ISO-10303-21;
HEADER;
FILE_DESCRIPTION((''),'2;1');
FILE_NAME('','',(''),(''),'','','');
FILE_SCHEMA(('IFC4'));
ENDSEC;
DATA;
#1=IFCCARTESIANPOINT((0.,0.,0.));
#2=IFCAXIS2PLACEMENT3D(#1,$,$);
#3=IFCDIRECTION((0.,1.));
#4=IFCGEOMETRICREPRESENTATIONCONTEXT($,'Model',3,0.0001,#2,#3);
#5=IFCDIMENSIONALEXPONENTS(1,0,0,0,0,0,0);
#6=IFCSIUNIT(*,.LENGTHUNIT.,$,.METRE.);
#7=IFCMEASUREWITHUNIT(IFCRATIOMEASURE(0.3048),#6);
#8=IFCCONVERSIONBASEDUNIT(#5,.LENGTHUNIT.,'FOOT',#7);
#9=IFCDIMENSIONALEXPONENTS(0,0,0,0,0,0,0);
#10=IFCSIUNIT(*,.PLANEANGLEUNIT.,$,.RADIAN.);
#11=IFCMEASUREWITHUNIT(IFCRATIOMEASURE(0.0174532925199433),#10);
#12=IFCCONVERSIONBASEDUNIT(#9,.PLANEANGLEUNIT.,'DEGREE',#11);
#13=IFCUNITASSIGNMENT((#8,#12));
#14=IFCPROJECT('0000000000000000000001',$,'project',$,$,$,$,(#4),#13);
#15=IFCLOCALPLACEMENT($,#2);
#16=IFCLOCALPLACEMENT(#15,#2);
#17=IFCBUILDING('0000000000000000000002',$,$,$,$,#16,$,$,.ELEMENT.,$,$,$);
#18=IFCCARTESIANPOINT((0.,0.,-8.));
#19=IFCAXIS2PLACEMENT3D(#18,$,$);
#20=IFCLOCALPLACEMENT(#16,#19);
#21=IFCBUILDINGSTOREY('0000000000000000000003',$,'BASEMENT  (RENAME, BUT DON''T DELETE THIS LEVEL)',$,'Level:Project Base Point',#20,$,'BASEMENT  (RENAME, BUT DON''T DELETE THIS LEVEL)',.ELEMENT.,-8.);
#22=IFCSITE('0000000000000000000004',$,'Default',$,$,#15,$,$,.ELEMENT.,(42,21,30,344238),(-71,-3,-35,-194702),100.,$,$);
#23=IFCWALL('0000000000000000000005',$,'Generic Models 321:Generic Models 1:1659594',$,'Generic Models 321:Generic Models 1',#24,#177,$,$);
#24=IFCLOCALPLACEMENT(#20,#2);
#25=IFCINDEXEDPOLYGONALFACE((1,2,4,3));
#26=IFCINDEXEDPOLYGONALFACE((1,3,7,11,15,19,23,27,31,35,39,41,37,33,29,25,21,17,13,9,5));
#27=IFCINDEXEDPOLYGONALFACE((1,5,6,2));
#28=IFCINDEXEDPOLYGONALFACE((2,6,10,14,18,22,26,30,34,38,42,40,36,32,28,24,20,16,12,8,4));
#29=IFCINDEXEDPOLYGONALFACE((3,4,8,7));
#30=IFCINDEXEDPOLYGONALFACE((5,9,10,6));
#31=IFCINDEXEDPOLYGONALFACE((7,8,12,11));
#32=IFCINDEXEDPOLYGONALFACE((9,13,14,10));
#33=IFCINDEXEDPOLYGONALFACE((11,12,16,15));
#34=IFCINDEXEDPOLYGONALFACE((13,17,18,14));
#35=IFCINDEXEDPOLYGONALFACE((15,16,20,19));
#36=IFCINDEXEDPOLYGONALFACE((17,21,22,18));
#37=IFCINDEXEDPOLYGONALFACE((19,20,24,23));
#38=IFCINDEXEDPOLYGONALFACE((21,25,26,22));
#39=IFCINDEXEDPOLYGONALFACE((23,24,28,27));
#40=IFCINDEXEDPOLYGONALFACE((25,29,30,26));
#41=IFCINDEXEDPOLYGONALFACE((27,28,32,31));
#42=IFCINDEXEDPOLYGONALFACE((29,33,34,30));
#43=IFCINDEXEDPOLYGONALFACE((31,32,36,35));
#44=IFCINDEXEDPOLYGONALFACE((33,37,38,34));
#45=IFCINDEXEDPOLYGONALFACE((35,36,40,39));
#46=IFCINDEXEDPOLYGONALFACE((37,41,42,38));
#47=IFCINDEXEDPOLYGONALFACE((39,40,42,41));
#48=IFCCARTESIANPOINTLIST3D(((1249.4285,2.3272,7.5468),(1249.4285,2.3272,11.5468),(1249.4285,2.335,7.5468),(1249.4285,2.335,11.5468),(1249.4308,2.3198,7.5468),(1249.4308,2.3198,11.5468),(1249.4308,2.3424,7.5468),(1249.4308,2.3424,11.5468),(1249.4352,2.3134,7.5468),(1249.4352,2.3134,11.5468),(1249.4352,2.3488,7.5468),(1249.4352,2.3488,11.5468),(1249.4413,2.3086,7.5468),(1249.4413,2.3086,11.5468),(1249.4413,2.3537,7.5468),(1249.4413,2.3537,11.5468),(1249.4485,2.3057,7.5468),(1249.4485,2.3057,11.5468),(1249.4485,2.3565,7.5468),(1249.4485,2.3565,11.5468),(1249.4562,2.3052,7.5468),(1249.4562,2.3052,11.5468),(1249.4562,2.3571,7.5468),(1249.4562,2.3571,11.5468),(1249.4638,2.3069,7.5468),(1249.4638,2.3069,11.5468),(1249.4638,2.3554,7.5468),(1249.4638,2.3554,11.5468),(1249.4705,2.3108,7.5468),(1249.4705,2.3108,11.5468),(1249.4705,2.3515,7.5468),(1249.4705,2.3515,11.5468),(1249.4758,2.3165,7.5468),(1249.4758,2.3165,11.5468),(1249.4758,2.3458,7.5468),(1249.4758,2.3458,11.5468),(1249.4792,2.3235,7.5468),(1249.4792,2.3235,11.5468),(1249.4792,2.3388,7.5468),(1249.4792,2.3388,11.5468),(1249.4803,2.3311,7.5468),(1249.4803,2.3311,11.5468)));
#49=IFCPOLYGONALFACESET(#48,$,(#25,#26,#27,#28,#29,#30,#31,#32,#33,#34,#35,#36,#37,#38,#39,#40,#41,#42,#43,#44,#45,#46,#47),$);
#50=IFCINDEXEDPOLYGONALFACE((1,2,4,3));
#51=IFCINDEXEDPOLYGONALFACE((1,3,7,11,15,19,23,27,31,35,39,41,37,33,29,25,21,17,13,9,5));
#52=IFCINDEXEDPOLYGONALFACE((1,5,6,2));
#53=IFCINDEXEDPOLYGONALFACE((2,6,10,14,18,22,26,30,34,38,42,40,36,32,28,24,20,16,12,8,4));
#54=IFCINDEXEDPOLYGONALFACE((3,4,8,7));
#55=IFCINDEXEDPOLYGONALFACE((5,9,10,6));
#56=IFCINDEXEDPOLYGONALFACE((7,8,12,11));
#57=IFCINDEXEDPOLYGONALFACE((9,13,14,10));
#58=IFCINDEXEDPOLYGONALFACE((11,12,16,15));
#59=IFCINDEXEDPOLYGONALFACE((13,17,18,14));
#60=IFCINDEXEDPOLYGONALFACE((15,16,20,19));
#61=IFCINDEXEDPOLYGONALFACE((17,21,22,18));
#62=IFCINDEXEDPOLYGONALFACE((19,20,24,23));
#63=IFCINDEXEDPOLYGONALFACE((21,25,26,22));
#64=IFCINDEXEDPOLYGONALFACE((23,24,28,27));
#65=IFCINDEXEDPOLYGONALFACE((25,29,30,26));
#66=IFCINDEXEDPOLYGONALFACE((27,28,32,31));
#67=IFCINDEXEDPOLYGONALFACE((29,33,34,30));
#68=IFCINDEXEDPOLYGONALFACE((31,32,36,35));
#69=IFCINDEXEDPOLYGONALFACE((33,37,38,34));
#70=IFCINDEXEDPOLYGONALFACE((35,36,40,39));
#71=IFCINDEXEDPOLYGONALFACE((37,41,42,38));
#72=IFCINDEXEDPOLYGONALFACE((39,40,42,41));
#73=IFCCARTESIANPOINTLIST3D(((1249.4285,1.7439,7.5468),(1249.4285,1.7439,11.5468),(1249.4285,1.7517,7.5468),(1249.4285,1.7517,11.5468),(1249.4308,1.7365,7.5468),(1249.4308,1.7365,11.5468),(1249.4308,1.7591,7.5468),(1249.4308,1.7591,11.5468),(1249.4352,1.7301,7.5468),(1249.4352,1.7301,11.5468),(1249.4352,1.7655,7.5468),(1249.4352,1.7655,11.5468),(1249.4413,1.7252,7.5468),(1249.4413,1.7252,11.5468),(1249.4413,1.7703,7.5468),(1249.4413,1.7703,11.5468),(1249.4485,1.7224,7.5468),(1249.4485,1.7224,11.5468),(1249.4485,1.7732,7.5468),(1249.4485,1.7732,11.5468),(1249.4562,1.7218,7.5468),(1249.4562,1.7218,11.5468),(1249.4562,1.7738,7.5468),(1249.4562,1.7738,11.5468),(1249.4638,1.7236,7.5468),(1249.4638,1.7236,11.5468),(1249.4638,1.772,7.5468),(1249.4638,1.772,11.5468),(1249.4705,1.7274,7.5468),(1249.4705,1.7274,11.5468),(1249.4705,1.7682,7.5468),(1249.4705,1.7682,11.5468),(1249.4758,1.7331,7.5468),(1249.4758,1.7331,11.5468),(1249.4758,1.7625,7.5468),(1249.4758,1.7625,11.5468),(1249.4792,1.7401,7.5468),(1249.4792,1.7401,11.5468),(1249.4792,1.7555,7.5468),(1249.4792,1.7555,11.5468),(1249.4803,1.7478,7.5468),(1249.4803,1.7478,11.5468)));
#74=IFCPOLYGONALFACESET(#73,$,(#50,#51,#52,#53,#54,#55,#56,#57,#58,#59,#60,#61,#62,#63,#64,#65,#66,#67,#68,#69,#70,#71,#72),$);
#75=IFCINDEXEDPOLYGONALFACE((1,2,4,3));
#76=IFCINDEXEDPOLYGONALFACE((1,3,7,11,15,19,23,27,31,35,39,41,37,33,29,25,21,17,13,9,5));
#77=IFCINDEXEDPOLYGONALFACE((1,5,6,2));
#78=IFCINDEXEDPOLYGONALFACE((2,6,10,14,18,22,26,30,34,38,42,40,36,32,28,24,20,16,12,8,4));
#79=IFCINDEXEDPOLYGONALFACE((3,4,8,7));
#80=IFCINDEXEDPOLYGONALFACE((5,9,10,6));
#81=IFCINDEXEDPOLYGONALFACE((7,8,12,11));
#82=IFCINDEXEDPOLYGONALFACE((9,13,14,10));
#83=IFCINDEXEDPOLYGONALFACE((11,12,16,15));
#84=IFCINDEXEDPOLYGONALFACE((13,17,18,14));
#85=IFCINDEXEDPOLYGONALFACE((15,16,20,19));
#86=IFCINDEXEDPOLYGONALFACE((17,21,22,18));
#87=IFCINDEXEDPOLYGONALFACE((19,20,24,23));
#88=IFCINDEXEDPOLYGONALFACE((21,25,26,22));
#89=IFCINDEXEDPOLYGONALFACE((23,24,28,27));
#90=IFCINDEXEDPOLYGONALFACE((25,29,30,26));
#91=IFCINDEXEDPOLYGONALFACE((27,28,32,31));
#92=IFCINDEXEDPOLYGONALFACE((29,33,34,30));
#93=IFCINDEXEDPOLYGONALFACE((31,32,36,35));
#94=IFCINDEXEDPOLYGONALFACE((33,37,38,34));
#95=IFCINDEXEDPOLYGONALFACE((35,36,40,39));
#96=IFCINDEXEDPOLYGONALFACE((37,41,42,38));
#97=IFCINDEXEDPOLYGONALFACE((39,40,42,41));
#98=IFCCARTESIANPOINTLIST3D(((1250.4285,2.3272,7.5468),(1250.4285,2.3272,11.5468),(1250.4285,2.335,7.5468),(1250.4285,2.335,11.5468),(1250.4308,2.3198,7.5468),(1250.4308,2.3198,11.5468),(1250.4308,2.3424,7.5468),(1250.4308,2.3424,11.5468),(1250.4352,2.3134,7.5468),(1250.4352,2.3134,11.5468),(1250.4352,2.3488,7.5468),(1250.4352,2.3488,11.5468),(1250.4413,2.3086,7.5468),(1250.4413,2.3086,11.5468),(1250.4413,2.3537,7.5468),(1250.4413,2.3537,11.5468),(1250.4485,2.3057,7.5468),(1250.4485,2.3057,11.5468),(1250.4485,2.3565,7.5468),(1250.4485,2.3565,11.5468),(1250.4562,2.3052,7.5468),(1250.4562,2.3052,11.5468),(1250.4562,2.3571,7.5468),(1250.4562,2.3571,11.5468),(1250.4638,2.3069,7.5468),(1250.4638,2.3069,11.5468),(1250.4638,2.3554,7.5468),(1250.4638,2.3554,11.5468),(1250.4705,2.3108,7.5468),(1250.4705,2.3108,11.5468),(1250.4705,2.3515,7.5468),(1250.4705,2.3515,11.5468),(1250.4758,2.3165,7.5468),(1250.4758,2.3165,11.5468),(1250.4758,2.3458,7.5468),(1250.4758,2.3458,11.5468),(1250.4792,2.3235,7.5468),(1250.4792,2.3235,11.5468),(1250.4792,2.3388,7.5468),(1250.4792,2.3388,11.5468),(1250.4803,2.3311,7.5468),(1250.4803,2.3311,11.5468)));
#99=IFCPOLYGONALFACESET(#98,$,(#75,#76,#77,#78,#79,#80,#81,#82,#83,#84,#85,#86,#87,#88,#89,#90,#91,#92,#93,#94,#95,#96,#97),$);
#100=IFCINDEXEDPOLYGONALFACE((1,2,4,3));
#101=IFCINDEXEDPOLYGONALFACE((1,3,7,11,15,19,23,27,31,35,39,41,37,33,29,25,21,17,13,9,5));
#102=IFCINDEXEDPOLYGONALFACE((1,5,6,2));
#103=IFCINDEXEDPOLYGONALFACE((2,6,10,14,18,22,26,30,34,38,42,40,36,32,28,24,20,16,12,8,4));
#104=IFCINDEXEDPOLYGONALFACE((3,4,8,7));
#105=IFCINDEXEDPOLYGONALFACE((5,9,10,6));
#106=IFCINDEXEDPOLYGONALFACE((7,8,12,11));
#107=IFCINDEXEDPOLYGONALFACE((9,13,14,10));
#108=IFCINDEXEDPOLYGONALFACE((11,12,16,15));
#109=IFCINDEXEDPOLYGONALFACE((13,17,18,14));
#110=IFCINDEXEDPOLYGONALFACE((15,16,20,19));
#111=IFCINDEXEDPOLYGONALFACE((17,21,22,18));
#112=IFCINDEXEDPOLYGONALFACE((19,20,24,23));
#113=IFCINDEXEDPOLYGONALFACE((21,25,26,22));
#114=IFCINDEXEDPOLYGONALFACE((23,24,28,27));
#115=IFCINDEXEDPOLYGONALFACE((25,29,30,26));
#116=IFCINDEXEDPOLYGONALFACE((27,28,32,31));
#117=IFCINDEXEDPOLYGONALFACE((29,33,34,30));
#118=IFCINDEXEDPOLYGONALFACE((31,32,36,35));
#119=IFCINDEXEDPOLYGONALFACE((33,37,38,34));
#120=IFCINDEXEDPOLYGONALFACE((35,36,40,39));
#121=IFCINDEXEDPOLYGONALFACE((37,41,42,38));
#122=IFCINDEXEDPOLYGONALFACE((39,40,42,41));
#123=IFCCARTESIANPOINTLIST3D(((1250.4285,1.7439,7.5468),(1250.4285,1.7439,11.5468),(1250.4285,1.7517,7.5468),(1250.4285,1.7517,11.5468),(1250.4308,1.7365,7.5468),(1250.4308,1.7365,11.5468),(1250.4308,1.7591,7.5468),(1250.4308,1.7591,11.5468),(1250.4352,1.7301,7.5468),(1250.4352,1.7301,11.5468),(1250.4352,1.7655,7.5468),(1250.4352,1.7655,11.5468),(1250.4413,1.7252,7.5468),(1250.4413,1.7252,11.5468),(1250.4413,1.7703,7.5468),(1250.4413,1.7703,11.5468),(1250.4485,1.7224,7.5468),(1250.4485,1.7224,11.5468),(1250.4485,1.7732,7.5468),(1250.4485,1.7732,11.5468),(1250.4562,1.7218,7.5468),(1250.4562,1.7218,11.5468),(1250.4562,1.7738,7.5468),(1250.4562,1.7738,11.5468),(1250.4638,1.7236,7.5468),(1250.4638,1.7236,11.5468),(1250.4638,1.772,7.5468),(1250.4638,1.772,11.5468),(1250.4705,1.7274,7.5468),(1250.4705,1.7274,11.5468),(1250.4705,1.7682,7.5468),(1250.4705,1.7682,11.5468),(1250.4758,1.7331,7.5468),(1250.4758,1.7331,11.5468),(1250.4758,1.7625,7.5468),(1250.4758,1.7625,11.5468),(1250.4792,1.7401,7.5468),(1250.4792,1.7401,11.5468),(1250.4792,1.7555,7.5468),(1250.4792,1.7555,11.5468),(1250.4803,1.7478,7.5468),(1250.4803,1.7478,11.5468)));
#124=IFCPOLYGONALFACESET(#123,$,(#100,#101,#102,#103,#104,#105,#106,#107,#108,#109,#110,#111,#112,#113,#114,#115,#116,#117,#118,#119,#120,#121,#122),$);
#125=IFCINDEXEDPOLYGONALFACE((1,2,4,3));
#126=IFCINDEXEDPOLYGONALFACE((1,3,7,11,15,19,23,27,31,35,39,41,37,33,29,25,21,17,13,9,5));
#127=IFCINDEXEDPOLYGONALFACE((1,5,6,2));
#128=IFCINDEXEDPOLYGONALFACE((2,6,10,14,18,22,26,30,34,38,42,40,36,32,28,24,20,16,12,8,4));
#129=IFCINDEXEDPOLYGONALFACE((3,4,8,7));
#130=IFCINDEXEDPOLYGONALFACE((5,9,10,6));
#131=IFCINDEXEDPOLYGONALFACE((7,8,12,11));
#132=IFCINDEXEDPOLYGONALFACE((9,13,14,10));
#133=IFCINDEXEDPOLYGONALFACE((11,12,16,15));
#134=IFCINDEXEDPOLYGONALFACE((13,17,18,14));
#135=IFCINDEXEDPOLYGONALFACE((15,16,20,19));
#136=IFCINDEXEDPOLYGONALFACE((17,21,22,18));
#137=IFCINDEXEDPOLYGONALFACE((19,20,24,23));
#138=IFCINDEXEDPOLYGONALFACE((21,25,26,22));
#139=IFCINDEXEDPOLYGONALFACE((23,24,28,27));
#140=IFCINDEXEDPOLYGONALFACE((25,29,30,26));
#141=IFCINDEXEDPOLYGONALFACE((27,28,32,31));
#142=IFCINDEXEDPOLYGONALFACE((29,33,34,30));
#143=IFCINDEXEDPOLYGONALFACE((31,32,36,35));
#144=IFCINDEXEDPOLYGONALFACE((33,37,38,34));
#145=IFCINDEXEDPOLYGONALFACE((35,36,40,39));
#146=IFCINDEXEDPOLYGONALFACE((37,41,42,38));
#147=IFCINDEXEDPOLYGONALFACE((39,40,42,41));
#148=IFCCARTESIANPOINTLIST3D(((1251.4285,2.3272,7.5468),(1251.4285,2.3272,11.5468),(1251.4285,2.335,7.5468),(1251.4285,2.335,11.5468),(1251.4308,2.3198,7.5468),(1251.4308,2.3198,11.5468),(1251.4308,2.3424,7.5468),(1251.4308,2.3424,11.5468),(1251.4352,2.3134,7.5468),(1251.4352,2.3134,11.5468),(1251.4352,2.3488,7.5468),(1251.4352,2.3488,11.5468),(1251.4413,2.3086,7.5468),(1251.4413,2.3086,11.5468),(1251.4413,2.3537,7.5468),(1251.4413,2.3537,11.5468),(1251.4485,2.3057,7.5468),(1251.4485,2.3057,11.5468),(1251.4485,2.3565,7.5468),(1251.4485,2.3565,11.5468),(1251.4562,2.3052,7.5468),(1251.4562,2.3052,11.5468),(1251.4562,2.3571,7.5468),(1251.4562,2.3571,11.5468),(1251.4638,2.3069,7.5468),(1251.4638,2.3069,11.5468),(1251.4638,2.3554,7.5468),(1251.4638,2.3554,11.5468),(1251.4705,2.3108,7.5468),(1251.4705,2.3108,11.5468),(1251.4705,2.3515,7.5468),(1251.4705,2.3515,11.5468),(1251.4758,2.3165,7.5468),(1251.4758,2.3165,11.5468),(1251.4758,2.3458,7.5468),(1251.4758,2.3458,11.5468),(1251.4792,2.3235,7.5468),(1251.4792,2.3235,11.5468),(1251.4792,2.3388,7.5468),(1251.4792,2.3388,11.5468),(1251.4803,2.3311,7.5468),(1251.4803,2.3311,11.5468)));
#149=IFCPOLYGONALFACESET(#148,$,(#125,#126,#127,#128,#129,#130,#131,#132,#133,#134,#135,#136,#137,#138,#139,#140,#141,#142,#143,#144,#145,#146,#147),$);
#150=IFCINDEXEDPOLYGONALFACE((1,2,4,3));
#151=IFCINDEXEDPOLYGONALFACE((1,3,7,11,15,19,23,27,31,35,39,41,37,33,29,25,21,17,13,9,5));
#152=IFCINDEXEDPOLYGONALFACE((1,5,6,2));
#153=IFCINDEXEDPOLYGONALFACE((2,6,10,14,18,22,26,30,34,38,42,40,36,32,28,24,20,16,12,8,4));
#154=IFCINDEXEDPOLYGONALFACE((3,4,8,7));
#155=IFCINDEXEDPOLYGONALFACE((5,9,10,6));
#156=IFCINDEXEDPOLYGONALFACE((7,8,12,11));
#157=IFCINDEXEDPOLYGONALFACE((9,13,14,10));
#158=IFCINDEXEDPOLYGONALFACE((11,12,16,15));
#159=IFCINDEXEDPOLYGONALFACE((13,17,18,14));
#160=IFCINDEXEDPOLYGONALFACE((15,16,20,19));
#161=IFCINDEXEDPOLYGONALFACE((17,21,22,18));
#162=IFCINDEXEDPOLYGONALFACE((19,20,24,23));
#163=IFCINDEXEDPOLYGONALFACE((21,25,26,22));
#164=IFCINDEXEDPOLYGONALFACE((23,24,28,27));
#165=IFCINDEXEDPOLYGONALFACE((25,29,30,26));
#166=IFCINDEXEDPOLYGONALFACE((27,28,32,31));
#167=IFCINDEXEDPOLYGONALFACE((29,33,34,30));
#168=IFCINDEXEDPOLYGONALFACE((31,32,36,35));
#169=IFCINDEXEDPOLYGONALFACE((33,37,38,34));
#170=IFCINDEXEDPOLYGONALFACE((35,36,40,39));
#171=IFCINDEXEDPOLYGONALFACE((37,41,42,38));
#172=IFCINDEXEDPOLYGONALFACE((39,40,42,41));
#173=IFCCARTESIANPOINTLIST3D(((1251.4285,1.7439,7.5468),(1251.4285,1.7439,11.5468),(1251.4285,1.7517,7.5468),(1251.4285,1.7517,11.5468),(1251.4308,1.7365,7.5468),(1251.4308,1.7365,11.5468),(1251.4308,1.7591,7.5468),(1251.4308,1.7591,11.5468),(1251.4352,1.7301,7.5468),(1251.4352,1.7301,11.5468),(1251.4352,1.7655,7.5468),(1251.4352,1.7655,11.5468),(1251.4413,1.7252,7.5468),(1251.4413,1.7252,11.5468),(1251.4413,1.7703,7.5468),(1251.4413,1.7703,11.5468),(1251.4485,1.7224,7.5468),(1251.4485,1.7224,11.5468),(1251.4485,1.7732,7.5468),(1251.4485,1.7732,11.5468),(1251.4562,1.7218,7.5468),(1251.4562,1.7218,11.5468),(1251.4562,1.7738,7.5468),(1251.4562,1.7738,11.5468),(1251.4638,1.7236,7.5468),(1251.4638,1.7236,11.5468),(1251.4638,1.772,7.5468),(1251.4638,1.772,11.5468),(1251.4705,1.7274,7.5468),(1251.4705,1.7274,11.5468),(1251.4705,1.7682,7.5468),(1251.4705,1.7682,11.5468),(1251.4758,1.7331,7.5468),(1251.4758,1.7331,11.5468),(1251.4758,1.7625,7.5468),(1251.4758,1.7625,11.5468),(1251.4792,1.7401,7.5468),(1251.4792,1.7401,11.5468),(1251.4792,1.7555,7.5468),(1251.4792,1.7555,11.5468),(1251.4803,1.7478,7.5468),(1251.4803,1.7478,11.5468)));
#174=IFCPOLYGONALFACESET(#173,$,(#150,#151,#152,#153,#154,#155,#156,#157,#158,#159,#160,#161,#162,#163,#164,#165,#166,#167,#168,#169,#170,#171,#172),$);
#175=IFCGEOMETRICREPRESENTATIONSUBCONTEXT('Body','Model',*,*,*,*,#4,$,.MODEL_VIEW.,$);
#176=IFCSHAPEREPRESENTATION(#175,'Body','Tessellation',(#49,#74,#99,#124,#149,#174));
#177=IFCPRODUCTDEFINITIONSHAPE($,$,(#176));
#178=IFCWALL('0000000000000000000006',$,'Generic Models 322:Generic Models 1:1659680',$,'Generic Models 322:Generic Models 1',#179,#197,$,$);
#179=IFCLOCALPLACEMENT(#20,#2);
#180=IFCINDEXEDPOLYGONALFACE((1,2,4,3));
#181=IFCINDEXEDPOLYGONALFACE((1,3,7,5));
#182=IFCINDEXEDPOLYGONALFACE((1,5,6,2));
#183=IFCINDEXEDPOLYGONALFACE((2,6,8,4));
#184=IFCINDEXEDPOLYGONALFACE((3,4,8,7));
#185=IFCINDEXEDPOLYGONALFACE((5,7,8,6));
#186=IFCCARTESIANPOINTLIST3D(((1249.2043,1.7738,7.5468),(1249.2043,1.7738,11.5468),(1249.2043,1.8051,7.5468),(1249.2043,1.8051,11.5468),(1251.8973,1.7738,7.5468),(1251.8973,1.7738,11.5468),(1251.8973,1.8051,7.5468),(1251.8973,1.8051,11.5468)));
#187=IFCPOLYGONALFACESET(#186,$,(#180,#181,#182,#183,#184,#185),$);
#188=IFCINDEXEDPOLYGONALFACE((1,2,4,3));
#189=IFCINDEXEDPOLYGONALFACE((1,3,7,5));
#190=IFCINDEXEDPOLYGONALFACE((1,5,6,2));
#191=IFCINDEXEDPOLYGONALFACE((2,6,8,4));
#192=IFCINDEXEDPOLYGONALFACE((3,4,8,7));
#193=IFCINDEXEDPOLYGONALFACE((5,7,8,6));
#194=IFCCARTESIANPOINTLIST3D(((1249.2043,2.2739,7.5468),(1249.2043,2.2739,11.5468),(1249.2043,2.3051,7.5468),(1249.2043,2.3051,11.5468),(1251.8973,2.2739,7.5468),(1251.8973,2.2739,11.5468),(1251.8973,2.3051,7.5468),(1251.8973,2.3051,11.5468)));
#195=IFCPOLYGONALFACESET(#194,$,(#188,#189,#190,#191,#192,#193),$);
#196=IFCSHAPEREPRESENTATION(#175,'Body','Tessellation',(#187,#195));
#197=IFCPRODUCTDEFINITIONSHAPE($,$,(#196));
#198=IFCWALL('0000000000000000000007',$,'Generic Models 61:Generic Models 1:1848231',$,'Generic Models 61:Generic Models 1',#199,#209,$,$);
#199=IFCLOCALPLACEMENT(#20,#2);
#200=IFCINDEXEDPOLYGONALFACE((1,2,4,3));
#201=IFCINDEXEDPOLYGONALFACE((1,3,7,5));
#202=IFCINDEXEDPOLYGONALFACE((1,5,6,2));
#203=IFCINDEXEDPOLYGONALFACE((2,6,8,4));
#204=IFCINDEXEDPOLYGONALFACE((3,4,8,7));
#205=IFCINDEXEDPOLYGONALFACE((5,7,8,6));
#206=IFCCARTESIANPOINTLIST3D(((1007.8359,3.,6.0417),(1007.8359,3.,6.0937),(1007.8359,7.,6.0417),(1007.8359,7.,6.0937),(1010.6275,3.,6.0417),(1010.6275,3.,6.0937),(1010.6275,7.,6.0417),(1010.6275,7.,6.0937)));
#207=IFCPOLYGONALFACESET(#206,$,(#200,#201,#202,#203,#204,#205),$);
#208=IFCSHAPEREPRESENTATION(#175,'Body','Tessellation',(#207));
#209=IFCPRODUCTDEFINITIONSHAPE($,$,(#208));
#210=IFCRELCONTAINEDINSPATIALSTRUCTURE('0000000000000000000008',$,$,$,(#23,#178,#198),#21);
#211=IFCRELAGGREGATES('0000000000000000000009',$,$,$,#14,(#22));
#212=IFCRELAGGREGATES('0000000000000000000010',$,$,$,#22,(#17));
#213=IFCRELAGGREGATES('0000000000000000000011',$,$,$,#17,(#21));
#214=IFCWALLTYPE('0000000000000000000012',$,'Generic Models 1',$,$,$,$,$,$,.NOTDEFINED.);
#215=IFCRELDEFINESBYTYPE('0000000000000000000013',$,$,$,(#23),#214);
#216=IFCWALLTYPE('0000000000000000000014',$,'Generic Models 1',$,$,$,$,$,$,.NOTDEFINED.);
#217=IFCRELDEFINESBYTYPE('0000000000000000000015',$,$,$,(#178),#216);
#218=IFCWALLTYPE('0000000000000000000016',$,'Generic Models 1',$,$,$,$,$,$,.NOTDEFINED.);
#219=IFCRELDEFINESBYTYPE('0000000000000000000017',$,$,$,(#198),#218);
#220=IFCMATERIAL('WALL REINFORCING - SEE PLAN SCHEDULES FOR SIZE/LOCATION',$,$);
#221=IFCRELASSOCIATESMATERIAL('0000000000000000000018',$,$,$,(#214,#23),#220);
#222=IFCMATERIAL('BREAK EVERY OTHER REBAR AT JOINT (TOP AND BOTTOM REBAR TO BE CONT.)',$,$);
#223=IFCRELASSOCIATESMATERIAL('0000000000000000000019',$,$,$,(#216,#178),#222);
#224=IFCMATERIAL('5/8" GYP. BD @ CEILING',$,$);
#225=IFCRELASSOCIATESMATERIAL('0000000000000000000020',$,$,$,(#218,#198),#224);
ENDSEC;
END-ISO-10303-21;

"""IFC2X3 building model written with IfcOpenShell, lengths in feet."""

from ifc_helpers import new_model, entity, si_unit, converted_unit, direction, frame, frame_2d, origin, origin_2d_with_axis, place, context, subcontext, project, spatial, rectangle, circle, extrude, material, type_object, element, save


model = new_model("IFC2X3")

# Units and contexts
model_context = context("Model", 3, precision=0.0001, world=origin(), true_north=direction((0.0, 1.0)))
body_context = subcontext(model_context, "Body", "Model", "MODEL_VIEW")
ifc_project = project(units=[converted_unit("LENGTHUNIT", "FOOT", entity("IfcRatioMeasure", 0.3048), si_unit("LENGTHUNIT", "METRE"), dimensions=[1, 0, 0, 0, 0, 0, 0]), converted_unit("PLANEANGLEUNIT", "DEGREE", entity("IfcRatioMeasure", 0.0174532925199433), si_unit("PLANEANGLEUNIT", "RADIAN"), dimensions=[0, 0, 0, 0, 0, 0, 0])], contexts=[model_context])

# Site, building, storey
site_placement = place(None, origin())
site = spatial("IfcSite", under=ifc_project, at=site_placement, Name="Default", CompositionType="ELEMENT", RefLatitude=(42, 21, 30, 344238), RefLongitude=(-71, -3, -35, -194702), RefElevation=100.0)
building_placement = place(site_placement, origin())
building = spatial("IfcBuilding", under=site, at=building_placement, CompositionType="ELEMENT")
storey_placement = place(building_placement, frame((0.0, 0.0, -8.0)))
storey = spatial("IfcBuildingStorey", under=building, at=storey_placement, Name="BASEMENT  (RENAME, BUT DON'T DELETE THIS LEVEL)", ObjectType="Level:Project Base Point", LongName="BASEMENT  (RENAME, BUT DON'T DELETE THIS LEVEL)", CompositionType="ELEMENT", Elevation=-8.0)

# Walls
ifc_material_1 = material(Name="WALL REINFORCING - SEE PLAN SCHEDULES FOR SIZE/LOCATION")
wall_type_1 = type_object("IfcWallType", Name="Generic Models 1", PredefinedType="NOTDEFINED", material=ifc_material_1)
wall_1_placement = place(storey_placement, frame((1249.4282, 1.7218, 7.5468)))
element("IfcWall", 1, at=wall_1_placement, inside=storey, type_object=wall_type_1, material=ifc_material_1, Name="Generic Models 321:Generic Models 1:1659594", ObjectType="Generic Models 321:Generic Models 1", context=body_context, shape_type="SweptSolid", body=[
    extrude(circle(Radius=0.026, at=origin_2d_with_axis()), frame((0.026, 0.6094, 0.0)), (0.0, 0.0, 1.0), 4.0),
    extrude(circle(Radius=0.026, at=origin_2d_with_axis()), frame((0.026, 0.026, 0.0)), (0.0, 0.0, 1.0), 4.0),
    extrude(circle(Radius=0.026, at=origin_2d_with_axis()), frame((1.026, 0.6094, 0.0)), (0.0, 0.0, 1.0), 4.0),
    extrude(circle(Radius=0.026, at=origin_2d_with_axis()), frame((1.026, 0.026, 0.0)), (0.0, 0.0, 1.0), 4.0),
    extrude(circle(Radius=0.026, at=origin_2d_with_axis()), frame((2.026, 0.6094, 0.0)), (0.0, 0.0, 1.0), 4.0),
    extrude(circle(Radius=0.026, at=origin_2d_with_axis()), frame((2.026, 0.026, 0.0)), (0.0, 0.0, 1.0), 4.0),
])
ifc_material_2 = material(Name="BREAK EVERY OTHER REBAR AT JOINT (TOP AND BOTTOM REBAR TO BE CONT.)")
wall_type_2 = type_object("IfcWallType", Name="Generic Models 1", PredefinedType="NOTDEFINED", material=ifc_material_2)
wall_2_placement = place(storey_placement, frame((1249.2043, 1.7738, 7.5468)))
element("IfcWall", 2, at=wall_2_placement, inside=storey, type_object=wall_type_2, material=ifc_material_2, Name="Generic Models 322:Generic Models 1:1659680", ObjectType="Generic Models 322:Generic Models 1", context=body_context, shape_type="SweptSolid", body=[
    extrude(rectangle(XDim=0.0312, YDim=2.693, at=origin_2d_with_axis()), frame((1.3465, 0.0156, 0.0), z_axis=(0.0, 0.0, 1.0), x_axis=(0.0, 1.0, 0.0)), (0.0, 0.0, 1.0), 4.0),
    extrude(rectangle(XDim=0.0312, YDim=2.693, at=origin_2d_with_axis()), frame((1.3465, 0.5157, 0.0), z_axis=(0.0, 0.0, 1.0), x_axis=(0.0, 1.0, 0.0)), (0.0, 0.0, 1.0), 4.0),
])
ifc_material_3 = material(Name="5/8\" GYP. BD @ CEILING")
wall_type_3 = type_object("IfcWallType", Name="Generic Models 1", PredefinedType="NOTDEFINED", material=ifc_material_3)
wall_3_placement = place(storey_placement, frame((1007.8359, 3.0, 6.0417), z_axis=(0.0, 0.0, 1.0), x_axis=(0.0, 1.0, 0.0)))
element("IfcWall", 3, at=wall_3_placement, inside=storey, type_object=wall_type_3, material=ifc_material_3, Name="Generic Models 61:Generic Models 1:1848231", ObjectType="Generic Models 61:Generic Models 1", context=body_context, shape_type="SweptSolid", body=[
    extrude(rectangle(XDim=4.0, YDim=2.7917, at=frame_2d((0.0, 0.0), x_axis=(1.0, 0.0))), frame((2.0, -1.3958, 0.0)), (0.0, 0.0, 1.0), 0.0521),
])

save(model, "model.ifc")
